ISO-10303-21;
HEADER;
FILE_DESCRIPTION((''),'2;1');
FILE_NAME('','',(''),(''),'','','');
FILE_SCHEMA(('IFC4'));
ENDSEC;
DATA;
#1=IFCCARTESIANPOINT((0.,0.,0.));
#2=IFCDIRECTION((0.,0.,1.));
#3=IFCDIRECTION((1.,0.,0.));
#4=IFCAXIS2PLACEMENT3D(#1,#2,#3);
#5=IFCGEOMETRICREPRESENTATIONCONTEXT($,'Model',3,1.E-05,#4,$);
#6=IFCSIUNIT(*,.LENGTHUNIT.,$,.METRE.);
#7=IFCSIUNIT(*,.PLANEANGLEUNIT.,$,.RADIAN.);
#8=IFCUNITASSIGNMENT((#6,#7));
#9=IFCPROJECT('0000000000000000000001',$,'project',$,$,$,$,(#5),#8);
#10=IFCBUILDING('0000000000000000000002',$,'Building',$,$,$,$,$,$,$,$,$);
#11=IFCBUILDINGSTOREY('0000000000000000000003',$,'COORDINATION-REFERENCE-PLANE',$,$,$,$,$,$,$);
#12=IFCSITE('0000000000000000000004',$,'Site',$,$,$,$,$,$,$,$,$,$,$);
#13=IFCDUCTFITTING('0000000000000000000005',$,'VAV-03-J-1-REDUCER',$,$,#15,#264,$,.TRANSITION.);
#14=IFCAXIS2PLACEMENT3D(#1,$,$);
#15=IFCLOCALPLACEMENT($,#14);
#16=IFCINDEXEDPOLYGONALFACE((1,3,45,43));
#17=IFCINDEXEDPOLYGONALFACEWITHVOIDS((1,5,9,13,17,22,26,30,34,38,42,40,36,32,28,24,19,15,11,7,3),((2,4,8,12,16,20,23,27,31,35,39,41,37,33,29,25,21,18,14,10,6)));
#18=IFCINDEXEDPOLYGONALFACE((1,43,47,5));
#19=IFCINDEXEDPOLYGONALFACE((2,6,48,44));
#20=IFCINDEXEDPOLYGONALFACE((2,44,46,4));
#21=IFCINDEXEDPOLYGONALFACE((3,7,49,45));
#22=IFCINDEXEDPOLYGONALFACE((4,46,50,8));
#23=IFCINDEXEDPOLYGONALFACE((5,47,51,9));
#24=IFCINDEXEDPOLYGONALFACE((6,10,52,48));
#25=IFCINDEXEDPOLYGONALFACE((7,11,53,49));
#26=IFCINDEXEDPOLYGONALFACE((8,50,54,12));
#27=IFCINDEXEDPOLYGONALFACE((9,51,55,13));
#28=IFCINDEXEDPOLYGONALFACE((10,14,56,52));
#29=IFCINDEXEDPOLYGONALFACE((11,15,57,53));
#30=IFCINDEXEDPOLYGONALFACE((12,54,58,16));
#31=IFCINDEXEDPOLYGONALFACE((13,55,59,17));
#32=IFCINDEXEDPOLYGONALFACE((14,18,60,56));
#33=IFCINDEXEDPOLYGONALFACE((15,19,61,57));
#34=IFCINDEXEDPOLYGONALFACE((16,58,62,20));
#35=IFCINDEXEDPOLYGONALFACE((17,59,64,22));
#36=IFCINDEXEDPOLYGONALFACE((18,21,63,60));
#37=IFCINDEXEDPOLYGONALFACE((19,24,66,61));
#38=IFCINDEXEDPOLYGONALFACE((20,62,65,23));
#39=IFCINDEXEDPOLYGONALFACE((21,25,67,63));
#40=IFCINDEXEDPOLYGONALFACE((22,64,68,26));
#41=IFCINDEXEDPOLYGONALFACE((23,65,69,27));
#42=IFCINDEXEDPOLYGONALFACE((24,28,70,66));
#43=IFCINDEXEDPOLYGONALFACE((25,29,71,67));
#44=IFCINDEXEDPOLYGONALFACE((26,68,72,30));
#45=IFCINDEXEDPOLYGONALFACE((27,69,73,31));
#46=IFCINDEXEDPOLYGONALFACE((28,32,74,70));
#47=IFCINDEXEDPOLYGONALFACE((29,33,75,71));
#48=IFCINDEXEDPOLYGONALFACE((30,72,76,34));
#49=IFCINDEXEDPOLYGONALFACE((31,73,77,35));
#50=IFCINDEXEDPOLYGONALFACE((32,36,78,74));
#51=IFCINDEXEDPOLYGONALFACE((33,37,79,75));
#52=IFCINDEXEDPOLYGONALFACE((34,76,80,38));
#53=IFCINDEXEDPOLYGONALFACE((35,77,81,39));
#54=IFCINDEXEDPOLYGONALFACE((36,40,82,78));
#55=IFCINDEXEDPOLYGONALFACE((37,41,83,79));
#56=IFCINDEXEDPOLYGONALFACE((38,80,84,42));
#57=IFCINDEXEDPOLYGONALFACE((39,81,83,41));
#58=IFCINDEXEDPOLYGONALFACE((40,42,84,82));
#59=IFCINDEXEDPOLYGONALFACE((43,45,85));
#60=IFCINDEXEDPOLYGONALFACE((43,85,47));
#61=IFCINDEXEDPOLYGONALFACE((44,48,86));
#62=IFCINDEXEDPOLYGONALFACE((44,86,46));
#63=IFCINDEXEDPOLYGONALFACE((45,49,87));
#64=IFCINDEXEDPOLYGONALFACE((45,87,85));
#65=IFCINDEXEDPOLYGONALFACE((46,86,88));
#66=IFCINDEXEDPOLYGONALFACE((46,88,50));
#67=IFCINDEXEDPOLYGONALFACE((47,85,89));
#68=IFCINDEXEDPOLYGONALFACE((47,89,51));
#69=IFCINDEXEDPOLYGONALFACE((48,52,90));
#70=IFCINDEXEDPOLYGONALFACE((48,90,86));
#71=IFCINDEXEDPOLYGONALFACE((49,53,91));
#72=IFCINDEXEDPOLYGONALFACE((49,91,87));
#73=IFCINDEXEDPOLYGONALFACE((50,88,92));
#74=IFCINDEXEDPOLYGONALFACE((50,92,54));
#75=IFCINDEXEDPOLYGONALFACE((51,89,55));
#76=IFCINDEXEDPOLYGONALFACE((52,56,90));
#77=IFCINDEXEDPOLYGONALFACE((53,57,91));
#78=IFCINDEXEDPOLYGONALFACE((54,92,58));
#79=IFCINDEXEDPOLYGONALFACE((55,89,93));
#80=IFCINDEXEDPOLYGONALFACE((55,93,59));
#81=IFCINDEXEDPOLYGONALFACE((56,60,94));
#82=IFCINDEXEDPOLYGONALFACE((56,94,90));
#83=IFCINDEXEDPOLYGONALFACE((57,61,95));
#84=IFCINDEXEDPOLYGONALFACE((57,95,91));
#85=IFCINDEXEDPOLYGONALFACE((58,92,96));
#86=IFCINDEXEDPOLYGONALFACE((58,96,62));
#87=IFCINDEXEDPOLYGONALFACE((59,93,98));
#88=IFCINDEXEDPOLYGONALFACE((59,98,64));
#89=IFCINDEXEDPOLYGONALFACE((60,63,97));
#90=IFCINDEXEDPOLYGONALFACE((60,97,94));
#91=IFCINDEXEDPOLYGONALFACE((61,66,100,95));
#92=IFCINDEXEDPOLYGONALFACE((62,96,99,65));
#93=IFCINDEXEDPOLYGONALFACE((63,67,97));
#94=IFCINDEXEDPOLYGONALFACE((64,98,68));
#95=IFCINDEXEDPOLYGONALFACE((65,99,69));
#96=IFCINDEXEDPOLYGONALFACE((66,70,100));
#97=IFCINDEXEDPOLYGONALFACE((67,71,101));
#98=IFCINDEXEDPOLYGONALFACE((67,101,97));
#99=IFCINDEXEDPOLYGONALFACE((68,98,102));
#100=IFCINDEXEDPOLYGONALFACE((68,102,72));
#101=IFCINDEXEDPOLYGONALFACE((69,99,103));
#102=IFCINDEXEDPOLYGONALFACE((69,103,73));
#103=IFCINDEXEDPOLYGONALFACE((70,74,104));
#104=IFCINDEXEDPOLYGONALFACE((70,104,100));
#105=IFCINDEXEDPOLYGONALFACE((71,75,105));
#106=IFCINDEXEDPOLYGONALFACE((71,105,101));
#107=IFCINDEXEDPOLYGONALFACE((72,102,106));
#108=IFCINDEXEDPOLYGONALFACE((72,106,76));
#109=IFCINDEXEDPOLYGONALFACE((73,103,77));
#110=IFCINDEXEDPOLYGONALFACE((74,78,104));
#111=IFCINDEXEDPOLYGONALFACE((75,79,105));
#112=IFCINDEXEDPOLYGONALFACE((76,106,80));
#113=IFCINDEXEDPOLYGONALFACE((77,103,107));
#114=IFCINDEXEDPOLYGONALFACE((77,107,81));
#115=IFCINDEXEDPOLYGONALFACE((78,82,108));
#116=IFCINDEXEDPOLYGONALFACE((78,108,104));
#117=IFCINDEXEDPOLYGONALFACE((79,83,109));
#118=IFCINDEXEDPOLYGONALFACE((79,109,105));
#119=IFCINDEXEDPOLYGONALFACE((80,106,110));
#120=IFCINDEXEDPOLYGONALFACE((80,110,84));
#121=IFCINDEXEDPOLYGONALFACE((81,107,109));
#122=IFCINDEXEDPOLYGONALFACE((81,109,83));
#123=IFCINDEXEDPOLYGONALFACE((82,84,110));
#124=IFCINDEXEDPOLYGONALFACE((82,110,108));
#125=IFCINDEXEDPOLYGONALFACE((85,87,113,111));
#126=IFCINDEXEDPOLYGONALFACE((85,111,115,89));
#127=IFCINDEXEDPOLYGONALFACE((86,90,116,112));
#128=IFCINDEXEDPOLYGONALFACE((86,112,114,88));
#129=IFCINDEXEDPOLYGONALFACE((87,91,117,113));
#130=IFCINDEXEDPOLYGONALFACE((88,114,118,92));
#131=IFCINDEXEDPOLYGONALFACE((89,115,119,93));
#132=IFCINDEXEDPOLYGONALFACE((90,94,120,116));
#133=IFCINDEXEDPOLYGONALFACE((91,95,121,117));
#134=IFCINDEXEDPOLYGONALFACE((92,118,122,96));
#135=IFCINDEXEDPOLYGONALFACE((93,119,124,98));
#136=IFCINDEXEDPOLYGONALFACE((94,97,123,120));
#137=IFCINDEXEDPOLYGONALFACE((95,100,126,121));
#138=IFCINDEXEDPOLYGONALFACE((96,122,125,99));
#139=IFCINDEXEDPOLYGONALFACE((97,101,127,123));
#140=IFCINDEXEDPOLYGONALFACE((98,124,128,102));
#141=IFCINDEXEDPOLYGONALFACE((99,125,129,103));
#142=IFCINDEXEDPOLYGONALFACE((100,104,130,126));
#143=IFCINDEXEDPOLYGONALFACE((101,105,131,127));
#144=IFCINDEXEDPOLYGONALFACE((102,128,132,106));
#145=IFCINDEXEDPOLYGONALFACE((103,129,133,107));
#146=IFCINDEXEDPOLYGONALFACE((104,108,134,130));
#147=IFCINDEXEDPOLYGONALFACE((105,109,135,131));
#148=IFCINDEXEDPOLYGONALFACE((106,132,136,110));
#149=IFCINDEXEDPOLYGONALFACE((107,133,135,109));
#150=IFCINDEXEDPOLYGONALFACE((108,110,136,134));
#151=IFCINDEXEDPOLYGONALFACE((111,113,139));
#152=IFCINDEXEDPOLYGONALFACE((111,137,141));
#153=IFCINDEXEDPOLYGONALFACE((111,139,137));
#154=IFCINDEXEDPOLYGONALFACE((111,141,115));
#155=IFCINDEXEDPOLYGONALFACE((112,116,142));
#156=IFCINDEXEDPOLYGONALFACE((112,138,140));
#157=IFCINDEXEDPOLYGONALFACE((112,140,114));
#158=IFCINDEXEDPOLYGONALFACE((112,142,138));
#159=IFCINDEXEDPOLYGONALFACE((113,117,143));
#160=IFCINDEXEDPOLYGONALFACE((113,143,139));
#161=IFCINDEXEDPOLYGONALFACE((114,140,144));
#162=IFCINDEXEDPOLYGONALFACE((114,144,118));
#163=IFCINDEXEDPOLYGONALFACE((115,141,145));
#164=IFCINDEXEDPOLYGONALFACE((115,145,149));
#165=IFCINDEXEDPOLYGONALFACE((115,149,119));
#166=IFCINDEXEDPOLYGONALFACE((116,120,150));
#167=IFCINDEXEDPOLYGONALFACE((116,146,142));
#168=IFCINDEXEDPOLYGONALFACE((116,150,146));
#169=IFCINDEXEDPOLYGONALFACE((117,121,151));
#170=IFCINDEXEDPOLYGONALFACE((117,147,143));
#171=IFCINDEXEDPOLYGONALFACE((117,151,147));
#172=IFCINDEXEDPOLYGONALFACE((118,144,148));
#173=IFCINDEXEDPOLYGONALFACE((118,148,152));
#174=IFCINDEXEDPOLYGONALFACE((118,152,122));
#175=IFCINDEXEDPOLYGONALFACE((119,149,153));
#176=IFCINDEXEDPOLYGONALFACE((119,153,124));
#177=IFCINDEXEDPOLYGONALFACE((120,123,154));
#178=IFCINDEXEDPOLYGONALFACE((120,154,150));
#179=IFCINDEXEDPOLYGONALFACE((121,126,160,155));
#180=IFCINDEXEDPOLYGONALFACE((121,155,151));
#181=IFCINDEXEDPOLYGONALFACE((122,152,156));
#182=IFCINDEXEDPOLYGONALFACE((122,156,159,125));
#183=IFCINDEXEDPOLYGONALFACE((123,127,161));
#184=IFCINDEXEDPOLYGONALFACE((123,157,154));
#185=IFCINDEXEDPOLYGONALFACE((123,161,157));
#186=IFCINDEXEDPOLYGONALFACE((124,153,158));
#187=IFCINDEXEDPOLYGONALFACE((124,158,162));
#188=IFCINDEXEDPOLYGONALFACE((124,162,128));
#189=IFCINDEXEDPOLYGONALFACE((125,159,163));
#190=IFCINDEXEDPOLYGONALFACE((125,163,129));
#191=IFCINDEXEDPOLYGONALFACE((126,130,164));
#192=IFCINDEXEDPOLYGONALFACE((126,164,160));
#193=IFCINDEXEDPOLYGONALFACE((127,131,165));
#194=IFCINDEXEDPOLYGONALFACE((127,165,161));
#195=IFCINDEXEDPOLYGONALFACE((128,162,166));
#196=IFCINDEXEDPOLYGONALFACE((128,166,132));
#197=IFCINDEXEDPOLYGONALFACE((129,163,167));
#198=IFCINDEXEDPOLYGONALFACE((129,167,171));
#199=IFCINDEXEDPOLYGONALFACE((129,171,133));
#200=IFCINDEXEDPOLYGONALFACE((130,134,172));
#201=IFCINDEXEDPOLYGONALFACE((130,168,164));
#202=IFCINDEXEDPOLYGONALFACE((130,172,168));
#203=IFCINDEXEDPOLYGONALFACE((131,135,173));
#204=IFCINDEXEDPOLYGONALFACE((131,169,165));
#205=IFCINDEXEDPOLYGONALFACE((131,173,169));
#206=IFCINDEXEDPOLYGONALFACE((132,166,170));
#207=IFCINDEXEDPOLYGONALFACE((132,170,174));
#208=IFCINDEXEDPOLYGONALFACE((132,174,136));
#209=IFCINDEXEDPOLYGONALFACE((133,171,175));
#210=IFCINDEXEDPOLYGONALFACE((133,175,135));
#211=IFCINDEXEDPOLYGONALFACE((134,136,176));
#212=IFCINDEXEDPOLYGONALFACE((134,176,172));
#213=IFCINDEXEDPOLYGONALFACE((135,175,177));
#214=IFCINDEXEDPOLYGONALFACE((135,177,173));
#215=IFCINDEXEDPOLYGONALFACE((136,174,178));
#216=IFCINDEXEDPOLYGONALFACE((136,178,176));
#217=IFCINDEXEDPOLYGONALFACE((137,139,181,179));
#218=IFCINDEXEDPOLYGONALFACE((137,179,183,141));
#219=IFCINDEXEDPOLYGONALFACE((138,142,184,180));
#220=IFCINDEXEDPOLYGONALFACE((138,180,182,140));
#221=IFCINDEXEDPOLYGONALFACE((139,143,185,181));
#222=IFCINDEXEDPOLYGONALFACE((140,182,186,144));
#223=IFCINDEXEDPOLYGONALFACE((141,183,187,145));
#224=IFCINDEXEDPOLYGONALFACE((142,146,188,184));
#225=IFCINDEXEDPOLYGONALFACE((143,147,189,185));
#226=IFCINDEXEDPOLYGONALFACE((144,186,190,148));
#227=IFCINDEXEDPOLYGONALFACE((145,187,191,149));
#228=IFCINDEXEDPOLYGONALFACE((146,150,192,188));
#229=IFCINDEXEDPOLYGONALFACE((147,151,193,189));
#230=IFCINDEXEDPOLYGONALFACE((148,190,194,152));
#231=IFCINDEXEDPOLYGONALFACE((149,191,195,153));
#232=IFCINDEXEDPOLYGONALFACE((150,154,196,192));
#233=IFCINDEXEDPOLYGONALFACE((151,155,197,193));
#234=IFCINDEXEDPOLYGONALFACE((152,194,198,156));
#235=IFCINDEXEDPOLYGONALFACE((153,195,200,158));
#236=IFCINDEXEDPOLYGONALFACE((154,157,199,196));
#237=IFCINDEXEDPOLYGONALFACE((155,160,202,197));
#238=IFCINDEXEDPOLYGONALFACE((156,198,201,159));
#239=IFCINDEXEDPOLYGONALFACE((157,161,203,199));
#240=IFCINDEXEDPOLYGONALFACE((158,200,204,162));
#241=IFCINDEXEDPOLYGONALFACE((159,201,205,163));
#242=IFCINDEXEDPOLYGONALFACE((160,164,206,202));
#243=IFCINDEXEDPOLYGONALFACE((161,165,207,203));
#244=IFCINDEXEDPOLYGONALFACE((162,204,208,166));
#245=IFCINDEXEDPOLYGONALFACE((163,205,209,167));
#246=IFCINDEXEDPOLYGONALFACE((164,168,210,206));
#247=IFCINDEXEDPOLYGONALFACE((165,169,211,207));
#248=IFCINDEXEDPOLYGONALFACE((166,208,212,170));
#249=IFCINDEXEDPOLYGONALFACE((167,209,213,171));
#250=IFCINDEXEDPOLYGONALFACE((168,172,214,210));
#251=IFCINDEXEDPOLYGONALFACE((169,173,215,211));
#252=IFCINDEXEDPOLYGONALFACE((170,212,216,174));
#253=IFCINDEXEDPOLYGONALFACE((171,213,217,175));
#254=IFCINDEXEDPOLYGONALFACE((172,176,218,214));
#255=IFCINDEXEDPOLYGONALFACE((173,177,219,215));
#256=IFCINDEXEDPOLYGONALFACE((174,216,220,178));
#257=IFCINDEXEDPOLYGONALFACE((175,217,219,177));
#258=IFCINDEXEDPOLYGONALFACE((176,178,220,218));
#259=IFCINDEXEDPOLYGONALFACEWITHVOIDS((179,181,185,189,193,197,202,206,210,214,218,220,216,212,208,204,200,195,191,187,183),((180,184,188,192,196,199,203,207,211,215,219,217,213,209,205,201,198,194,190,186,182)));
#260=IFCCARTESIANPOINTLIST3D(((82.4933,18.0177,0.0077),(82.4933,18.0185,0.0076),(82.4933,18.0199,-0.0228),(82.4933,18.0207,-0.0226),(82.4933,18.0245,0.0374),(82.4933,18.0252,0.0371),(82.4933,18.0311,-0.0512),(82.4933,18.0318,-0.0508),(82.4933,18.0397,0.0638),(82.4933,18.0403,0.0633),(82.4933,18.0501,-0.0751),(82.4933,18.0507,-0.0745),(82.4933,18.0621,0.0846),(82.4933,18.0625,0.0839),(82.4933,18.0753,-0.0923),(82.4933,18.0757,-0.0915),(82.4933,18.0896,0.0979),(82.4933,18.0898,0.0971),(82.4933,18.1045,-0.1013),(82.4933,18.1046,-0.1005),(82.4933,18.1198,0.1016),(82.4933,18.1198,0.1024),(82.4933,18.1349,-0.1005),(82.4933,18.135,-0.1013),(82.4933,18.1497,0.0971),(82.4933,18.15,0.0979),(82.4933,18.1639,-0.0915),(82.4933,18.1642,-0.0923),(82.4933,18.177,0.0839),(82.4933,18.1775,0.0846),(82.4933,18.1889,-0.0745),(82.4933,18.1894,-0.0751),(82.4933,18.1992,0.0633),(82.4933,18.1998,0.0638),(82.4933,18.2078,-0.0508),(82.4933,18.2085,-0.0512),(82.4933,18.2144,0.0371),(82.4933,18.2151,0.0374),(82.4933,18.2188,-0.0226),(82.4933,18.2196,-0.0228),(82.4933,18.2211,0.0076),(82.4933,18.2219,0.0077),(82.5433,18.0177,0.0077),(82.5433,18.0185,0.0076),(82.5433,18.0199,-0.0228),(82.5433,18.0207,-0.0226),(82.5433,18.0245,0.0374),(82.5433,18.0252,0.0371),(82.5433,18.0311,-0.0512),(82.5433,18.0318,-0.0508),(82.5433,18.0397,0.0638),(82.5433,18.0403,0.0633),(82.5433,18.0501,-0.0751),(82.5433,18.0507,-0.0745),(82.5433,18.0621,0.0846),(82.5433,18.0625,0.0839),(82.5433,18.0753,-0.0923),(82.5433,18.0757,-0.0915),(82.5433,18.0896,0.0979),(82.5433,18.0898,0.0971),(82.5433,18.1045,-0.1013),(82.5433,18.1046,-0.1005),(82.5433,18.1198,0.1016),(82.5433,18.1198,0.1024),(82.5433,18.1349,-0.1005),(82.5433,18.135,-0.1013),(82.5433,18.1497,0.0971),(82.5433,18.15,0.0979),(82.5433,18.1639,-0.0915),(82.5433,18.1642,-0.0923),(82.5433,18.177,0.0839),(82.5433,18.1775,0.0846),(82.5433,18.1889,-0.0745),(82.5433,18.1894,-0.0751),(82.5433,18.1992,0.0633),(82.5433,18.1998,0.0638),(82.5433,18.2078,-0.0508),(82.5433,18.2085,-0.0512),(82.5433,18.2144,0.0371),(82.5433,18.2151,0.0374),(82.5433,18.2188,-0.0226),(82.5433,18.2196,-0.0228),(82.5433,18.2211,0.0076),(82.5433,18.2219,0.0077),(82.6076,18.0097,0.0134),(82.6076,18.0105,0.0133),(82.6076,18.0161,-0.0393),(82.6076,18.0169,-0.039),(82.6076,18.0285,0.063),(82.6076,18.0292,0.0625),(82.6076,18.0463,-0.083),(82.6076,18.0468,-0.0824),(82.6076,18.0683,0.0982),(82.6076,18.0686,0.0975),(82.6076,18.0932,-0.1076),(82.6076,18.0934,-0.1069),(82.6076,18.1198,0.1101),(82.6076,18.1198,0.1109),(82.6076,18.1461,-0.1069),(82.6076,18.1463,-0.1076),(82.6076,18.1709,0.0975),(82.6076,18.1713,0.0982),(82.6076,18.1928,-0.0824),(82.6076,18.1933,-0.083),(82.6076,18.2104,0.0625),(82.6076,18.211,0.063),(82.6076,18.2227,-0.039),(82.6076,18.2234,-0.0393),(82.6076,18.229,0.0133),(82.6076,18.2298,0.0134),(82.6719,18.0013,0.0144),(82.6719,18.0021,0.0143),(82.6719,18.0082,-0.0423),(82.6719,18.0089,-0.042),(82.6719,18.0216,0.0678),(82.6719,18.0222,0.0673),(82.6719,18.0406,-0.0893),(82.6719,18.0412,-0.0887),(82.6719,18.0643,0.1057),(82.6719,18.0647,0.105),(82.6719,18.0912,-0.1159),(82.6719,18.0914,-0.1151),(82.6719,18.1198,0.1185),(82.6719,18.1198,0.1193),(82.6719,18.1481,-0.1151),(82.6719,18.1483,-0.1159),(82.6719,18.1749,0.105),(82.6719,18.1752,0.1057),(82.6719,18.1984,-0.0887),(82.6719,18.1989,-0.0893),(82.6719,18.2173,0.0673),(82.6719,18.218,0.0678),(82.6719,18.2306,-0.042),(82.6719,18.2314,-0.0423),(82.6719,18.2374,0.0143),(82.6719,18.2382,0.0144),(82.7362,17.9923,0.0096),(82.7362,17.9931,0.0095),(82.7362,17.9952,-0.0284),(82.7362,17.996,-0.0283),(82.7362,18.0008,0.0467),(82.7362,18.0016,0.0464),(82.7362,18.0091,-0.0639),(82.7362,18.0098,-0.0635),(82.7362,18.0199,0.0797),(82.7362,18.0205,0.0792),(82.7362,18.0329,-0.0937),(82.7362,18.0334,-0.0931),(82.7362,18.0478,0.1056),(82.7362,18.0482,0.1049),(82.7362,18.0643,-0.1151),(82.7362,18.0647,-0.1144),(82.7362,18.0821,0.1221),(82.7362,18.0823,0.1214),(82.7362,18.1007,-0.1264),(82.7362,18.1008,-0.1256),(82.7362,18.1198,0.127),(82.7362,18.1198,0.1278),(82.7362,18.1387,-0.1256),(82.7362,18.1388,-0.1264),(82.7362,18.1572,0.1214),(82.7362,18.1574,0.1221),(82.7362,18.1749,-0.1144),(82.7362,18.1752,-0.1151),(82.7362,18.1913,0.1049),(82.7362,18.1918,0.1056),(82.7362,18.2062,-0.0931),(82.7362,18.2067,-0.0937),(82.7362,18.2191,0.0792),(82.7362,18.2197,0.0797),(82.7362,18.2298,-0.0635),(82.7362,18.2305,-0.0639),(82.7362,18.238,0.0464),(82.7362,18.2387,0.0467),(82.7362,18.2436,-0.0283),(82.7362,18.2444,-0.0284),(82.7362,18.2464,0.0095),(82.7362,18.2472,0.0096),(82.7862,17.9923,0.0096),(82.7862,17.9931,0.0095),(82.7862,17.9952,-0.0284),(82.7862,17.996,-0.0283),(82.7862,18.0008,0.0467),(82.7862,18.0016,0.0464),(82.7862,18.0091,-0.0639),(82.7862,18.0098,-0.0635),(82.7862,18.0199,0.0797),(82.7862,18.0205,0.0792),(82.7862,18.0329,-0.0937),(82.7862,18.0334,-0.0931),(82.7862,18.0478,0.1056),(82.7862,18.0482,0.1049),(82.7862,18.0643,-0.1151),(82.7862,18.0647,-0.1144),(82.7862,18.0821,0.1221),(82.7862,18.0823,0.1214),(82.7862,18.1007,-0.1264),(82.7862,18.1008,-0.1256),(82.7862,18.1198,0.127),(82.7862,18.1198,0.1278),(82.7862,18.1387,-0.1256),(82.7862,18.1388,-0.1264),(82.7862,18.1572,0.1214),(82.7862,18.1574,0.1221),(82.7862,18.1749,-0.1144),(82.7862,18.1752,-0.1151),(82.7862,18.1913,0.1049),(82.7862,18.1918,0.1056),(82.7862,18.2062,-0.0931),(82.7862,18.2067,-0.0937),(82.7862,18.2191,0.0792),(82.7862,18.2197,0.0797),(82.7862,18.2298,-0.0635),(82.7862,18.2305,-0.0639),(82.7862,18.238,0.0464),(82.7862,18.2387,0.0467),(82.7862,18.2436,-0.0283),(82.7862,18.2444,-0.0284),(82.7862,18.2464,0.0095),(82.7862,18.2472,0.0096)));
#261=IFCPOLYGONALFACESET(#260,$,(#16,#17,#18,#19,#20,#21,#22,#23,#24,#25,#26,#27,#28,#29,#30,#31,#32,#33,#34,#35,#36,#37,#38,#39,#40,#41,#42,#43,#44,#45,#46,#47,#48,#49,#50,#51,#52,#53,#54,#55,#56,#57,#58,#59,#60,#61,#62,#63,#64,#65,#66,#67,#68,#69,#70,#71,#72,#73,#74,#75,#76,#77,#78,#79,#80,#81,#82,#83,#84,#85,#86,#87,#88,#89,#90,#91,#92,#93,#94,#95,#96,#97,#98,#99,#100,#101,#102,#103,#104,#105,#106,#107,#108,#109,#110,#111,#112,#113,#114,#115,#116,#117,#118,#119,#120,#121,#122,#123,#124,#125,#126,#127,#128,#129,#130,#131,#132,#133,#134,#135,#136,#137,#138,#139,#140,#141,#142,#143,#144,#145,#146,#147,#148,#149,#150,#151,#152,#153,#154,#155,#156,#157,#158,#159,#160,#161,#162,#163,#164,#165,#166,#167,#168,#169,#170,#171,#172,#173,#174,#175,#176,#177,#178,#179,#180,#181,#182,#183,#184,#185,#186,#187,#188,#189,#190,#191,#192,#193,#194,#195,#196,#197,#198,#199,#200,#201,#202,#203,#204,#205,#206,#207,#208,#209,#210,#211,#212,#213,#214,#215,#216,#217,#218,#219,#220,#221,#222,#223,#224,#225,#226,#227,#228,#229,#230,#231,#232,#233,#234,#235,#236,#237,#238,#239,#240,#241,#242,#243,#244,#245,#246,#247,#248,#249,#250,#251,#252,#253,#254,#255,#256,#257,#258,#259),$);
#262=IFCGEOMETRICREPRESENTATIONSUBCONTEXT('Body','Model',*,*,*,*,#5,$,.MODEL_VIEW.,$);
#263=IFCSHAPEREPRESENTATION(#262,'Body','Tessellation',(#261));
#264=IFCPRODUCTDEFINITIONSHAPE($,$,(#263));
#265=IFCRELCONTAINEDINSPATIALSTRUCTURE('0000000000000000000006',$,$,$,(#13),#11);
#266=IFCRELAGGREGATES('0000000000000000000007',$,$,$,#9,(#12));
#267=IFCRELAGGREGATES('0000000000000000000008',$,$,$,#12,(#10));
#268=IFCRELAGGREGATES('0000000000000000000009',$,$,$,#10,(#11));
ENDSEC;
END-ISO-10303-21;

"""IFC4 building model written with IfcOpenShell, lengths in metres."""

from ifc_helpers import new_model, entity, si_unit, frame, origin_with_axes, place, context, subcontext, project, spatial, element, save


model = new_model("IFC4")

# Units and contexts
model_context = context("Model", 3, precision=1e-05, world=origin_with_axes())
body_context_1 = subcontext(model_context, "Body", "Model", "MODEL_VIEW")
ifc_project = project(units=[si_unit("LENGTHUNIT", "METRE"), si_unit("PLANEANGLEUNIT", "RADIAN")], contexts=[model_context])

# Site, building, storey
site = spatial("IfcSite", under=ifc_project, Name="Site")
building = spatial("IfcBuilding", under=site, Name="Building")
storey = spatial("IfcBuildingStorey", under=building, Name="COORDINATION-REFERENCE-PLANE")

# Duct fitting
for number, where, z_axis, x_axis, name in (
    (1, (82.7862, 18.1198, 0.0), (0.0, -1.0, 0.0), (0.0, 0.0, 1.0), "VAV-03-J-1-REDUCER"),
):
    element("IfcDuctFitting", number, at=place(None, frame(where, z_axis=z_axis, x_axis=x_axis)), inside=storey, Name=name, PredefinedType="TRANSITION", context=body_context_1, shape_type="SweptSolid", body=[
        entity("IfcRevolvedAreaSolid", entity("IfcArbitraryClosedProfileDef", "AREA", None, entity("IfcPolyline", [entity("IfcCartesianPoint", [0.1278, 0.0]), entity("IfcCartesianPoint", [0.1278, 0.05]), entity("IfcCartesianPoint", [0.1024, 0.2429]), entity("IfcCartesianPoint", [0.1024, 0.2929]), entity("IfcCartesianPoint", [0.1016, 0.2929]), entity("IfcCartesianPoint", [0.1016, 0.2429]), entity("IfcCartesianPoint", [0.127, 0.05]), entity("IfcCartesianPoint", [0.127, 0.0]), entity("IfcCartesianPoint", [0.1278, 0.0])])), entity("IfcAxis2Placement3D", entity("IfcCartesianPoint", [0.0, 0.0, 0.0])), entity("IfcAxis1Placement", entity("IfcCartesianPoint", [0.0, 0.0, 0.0]), entity("IfcDirection", [0.0, 1.0, 0.0])), 6.283185),
    ])

save(model, "model.ifc")
